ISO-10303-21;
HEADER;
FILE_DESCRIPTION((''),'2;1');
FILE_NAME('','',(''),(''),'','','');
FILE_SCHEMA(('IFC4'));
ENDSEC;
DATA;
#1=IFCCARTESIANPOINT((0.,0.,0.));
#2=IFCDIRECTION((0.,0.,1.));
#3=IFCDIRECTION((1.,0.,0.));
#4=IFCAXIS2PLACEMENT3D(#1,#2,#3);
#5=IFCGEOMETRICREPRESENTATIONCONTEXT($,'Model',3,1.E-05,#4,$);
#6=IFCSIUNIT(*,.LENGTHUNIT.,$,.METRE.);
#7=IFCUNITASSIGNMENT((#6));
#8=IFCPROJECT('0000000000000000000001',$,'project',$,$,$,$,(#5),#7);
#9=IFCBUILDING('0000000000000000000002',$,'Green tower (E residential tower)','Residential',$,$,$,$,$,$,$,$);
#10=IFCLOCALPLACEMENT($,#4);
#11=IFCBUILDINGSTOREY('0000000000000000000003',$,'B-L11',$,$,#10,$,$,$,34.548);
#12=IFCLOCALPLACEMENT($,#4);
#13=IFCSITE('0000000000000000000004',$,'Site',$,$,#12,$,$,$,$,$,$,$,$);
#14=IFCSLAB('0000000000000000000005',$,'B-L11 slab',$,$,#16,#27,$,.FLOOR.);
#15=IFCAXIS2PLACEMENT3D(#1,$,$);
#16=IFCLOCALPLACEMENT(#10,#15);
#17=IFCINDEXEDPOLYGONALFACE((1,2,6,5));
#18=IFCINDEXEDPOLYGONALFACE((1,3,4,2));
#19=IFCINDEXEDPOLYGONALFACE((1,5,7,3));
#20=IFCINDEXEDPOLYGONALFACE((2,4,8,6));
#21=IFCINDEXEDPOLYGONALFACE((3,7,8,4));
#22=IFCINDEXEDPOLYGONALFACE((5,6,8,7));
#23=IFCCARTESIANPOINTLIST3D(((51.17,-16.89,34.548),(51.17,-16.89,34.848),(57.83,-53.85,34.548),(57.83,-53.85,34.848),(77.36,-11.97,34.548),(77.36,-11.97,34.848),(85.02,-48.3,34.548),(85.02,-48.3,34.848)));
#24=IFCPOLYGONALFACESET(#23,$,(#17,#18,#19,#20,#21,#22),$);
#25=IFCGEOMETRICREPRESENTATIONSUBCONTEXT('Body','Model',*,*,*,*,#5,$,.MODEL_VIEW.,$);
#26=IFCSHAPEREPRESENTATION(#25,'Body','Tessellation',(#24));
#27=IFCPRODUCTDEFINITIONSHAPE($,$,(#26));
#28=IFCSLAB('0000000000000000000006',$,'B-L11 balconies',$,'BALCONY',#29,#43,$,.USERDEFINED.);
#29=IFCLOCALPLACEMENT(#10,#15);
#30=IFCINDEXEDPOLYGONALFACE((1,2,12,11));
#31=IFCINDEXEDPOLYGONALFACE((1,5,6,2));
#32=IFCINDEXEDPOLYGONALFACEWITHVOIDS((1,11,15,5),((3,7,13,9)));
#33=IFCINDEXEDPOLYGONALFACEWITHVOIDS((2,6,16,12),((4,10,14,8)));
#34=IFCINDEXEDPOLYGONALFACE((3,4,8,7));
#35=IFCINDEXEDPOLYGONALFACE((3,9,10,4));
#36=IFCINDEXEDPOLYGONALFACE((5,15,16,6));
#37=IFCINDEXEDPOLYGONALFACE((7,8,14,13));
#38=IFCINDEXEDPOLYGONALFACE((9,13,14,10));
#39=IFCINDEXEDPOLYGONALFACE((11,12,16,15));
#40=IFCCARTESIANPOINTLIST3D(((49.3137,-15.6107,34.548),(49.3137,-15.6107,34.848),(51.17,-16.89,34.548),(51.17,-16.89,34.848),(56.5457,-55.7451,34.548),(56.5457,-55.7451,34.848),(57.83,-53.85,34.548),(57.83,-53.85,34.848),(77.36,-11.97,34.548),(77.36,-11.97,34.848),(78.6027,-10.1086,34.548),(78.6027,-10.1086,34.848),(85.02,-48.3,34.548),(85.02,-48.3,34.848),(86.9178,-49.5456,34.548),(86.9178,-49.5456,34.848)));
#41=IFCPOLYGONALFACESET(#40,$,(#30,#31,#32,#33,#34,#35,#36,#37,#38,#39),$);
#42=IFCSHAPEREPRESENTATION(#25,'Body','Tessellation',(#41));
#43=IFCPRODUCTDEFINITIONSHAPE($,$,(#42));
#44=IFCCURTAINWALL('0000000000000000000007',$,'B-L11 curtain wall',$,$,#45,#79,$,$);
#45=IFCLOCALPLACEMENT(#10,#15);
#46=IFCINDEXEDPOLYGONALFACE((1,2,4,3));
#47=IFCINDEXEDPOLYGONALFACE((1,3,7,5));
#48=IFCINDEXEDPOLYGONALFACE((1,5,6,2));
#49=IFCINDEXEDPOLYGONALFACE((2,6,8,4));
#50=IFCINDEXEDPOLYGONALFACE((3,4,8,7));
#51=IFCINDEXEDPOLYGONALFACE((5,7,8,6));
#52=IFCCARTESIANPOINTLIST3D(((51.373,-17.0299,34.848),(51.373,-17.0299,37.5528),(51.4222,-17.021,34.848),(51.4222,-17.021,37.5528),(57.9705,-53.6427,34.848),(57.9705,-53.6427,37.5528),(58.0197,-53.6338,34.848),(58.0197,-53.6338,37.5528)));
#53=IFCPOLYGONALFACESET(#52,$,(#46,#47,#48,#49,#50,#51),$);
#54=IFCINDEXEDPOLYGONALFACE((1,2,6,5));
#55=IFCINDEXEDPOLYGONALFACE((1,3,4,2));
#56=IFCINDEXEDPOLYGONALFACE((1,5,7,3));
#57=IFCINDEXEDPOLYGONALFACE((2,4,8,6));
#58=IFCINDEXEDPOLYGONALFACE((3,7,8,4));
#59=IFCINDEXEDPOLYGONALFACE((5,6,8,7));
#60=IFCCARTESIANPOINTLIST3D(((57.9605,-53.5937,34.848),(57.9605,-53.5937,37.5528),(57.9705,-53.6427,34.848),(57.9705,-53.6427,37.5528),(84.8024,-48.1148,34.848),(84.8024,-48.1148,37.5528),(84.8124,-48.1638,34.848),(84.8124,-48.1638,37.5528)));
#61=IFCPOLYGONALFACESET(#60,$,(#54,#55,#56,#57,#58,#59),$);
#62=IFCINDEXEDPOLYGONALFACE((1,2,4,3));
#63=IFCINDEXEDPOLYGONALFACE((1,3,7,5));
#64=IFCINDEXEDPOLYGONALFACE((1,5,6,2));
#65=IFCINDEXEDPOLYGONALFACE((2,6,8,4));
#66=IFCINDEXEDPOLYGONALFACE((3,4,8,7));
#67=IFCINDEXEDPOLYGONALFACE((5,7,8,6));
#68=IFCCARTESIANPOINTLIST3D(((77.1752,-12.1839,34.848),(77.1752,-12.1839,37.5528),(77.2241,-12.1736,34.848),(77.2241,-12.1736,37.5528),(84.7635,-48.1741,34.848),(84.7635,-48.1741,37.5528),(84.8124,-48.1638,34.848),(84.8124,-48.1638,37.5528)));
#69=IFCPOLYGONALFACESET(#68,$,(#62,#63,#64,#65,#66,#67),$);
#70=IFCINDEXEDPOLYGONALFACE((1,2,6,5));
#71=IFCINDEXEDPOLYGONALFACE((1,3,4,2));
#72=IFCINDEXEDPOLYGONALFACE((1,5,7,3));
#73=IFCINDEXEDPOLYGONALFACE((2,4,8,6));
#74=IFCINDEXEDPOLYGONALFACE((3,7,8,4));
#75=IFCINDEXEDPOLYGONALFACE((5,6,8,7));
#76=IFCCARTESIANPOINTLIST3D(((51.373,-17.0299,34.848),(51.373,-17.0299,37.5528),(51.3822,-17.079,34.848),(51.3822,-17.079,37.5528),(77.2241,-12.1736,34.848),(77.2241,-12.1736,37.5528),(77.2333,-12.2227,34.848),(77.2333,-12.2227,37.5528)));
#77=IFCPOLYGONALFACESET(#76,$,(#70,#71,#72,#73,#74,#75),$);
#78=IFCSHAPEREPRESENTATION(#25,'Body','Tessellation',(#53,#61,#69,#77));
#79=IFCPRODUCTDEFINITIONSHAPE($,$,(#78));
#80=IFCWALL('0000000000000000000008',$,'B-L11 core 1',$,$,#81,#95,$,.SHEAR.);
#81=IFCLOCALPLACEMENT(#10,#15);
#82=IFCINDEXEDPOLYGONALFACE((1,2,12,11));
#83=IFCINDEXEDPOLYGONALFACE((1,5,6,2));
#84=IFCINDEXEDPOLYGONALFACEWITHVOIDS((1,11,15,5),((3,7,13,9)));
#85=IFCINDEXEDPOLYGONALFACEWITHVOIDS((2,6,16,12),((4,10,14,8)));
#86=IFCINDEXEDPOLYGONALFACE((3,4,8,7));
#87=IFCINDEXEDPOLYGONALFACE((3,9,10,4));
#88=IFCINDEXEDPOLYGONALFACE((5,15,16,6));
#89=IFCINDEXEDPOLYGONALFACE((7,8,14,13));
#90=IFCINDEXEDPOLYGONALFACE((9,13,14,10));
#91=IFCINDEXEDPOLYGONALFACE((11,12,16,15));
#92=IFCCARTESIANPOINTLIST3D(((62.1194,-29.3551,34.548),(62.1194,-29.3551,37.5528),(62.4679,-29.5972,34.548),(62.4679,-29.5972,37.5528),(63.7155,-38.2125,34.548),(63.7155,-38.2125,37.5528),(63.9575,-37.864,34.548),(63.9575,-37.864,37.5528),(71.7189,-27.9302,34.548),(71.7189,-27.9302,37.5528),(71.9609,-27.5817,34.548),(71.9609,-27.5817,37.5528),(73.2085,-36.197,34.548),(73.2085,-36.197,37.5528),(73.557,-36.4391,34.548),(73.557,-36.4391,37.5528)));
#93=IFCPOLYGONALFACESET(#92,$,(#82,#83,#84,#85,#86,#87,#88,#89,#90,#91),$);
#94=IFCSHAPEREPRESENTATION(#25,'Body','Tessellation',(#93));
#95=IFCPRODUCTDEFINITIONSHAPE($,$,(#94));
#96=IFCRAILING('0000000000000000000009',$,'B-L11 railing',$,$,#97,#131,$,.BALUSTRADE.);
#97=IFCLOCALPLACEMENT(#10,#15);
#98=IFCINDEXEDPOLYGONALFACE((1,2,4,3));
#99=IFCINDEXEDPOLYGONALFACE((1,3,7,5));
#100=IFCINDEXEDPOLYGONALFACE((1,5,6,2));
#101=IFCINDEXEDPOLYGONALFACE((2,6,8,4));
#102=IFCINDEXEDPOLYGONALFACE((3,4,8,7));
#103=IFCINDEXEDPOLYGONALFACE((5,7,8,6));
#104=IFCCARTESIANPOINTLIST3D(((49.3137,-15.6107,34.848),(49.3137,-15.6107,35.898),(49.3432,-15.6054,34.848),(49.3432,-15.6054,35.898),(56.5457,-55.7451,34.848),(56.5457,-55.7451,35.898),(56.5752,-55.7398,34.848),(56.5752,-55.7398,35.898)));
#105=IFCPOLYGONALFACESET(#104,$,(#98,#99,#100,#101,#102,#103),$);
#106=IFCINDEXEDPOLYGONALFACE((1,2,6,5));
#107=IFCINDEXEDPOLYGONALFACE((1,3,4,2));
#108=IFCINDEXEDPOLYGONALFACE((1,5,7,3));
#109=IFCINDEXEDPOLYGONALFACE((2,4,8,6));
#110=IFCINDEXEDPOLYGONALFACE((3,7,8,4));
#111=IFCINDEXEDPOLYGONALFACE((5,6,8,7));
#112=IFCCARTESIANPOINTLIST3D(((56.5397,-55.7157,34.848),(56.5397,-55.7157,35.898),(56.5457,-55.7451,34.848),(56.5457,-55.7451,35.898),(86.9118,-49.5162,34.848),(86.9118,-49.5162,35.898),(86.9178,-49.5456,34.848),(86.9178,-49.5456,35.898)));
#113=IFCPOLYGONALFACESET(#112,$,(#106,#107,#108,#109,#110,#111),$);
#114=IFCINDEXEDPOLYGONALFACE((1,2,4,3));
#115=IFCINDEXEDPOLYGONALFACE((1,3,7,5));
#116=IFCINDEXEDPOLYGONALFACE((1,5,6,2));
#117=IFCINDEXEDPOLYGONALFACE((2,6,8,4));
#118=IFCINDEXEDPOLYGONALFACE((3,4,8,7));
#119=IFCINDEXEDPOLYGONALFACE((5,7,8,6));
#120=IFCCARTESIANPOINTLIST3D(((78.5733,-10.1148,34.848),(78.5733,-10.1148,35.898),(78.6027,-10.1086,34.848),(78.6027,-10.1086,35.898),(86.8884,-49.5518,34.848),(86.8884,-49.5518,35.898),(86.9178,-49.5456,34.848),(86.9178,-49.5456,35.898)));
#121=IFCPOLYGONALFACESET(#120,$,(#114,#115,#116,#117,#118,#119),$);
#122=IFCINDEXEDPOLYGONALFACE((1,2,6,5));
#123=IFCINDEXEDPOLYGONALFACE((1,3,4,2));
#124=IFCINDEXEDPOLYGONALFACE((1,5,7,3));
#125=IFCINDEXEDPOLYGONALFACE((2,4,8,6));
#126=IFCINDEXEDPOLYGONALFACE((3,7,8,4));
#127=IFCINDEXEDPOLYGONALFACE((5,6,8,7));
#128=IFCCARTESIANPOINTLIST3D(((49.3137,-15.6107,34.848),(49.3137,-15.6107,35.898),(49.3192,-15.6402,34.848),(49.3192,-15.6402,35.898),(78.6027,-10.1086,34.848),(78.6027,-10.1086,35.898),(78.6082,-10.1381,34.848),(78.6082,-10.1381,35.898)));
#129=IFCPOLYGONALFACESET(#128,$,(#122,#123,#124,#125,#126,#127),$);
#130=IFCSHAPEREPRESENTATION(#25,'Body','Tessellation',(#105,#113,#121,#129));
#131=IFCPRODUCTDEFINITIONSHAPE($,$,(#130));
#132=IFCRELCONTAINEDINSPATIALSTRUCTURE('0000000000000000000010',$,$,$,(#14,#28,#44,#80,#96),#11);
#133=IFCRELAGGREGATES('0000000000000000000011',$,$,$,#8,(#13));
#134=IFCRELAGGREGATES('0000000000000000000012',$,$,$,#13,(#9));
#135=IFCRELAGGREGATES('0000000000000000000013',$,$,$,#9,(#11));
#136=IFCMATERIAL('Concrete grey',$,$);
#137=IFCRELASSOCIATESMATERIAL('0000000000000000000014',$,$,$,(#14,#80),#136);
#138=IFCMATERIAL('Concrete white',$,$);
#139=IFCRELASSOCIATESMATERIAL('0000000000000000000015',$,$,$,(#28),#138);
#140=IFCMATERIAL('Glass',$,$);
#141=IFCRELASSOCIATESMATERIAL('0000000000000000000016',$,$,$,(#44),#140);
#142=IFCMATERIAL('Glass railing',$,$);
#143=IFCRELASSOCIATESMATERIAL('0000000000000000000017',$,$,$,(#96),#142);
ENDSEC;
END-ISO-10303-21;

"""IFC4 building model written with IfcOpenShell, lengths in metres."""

from ifc_helpers import new_model, si_unit, frame, origin_with_axes, place, context, subcontext, project, spatial, polyline, outline, extrude, material, element, save


model = new_model("IFC4")

# Units and contexts
model_context = context("Model", 3, precision=1e-05, world=origin_with_axes())
body_context = subcontext(model_context, "Body", "Model", "MODEL_VIEW")
ifc_project = project(units=[si_unit("LENGTHUNIT", "METRE")], contexts=[model_context])

# Site, building, storey
site_placement = place(None, origin_with_axes())
site = spatial("IfcSite", under=ifc_project, at=site_placement, Name="Site")
building = spatial("IfcBuilding", under=site, Name="Green tower (E residential tower)", Description="Residential")
storey_placement = place(None, origin_with_axes())
storey = spatial("IfcBuildingStorey", under=building, at=storey_placement, Name="B-L11", Elevation=34.548)

# Slabs
ifc_material_1 = material(Name="Concrete grey")
slab_1_placement = place(storey_placement, origin_with_axes())
element("IfcSlab", 1, at=slab_1_placement, inside=storey, material=ifc_material_1, Name="B-L11 slab", PredefinedType="FLOOR", context=body_context, shape_type="SweptSolid", body=[
    extrude(outline(polyline([(51.17, -16.89), (57.83, -53.85), (85.02, -48.3), (77.36, -11.97), (51.17, -16.89)])), frame((0.0, 0.0, 34.548), z_axis=(0.0, 0.0, 1.0), x_axis=(1.0, 0.0, 0.0)), (0.0, 0.0, 1.0), 0.3),
])
ifc_material_2 = material(Name="Concrete white")
slab_2_placement = place(storey_placement, origin_with_axes())
element("IfcSlab", 2, at=slab_2_placement, inside=storey, material=ifc_material_2, Name="B-L11 balconies", ObjectType="BALCONY", PredefinedType="USERDEFINED", context=body_context, shape_type="SweptSolid", body=[
    extrude(outline(polyline([(49.3137, -15.6107), (56.5457, -55.7451), (86.9178, -49.5456), (78.6027, -10.1086), (49.3137, -15.6107)]), holes=[polyline([(51.17, -16.89), (57.83, -53.85), (85.02, -48.3), (77.36, -11.97), (51.17, -16.89)])]), frame((0.0, 0.0, 34.548), z_axis=(0.0, 0.0, 1.0), x_axis=(1.0, 0.0, 0.0)), (0.0, 0.0, 1.0), 0.3),
])

# Curtain wall
ifc_material_3 = material(Name="Glass")
curtain_wall_placement = place(storey_placement, origin_with_axes())
element("IfcCurtainWall", 3, at=curtain_wall_placement, inside=storey, material=ifc_material_3, Name="B-L11 curtain wall", context=body_context, shape_type="SweptSolid", body=[
    extrude(outline(polyline([(51.373, -17.0299), (57.9705, -53.6427), (58.0197, -53.6338), (51.4222, -17.021), (51.373, -17.0299)])), frame((0.0, 0.0, 34.848), z_axis=(0.0, 0.0, 1.0), x_axis=(1.0, 0.0, 0.0)), (0.0, 0.0, 1.0), 2.7048),
    extrude(outline(polyline([(57.9705, -53.6427), (84.8124, -48.1638), (84.8024, -48.1148), (57.9605, -53.5937), (57.9705, -53.6427)])), frame((0.0, 0.0, 34.848), z_axis=(0.0, 0.0, 1.0), x_axis=(1.0, 0.0, 0.0)), (0.0, 0.0, 1.0), 2.7048),
    extrude(outline(polyline([(84.8124, -48.1638), (77.2241, -12.1736), (77.1752, -12.1839), (84.7635, -48.1741), (84.8124, -48.1638)])), frame((0.0, 0.0, 34.848), z_axis=(0.0, 0.0, 1.0), x_axis=(1.0, 0.0, 0.0)), (0.0, 0.0, 1.0), 2.7048),
    extrude(outline(polyline([(77.2241, -12.1736), (51.373, -17.0299), (51.3822, -17.079), (77.2333, -12.2227), (77.2241, -12.1736)])), frame((0.0, 0.0, 34.848), z_axis=(0.0, 0.0, 1.0), x_axis=(1.0, 0.0, 0.0)), (0.0, 0.0, 1.0), 2.7048),
])

# Wall
wall_placement = place(storey_placement, origin_with_axes())
element("IfcWall", 4, at=wall_placement, inside=storey, material=ifc_material_1, Name="B-L11 core 1", PredefinedType="SHEAR", context=body_context, shape_type="SweptSolid", body=[
    extrude(outline(polyline([(62.1194, -29.3551), (63.7155, -38.2125), (73.557, -36.4391), (71.9609, -27.5817), (62.1194, -29.3551)]), holes=[polyline([(62.4679, -29.5972), (63.9575, -37.864), (73.2085, -36.197), (71.7189, -27.9302), (62.4679, -29.5972)])]), frame((0.0, 0.0, 34.548), z_axis=(0.0, 0.0, 1.0), x_axis=(1.0, 0.0, 0.0)), (0.0, 0.0, 1.0), 3.0048),
])

# Railing
ifc_material_4 = material(Name="Glass railing")
railing_placement = place(storey_placement, origin_with_axes())
element("IfcRailing", 5, at=railing_placement, inside=storey, material=ifc_material_4, Name="B-L11 railing", PredefinedType="BALUSTRADE", context=body_context, shape_type="SweptSolid", body=[
    extrude(outline(polyline([(49.3137, -15.6107), (56.5457, -55.7451), (56.5752, -55.7398), (49.3432, -15.6054), (49.3137, -15.6107)])), frame((0.0, 0.0, 34.848), z_axis=(0.0, 0.0, 1.0), x_axis=(1.0, 0.0, 0.0)), (0.0, 0.0, 1.0), 1.05),
    extrude(outline(polyline([(56.5457, -55.7451), (86.9178, -49.5456), (86.9118, -49.5162), (56.5397, -55.7157), (56.5457, -55.7451)])), frame((0.0, 0.0, 34.848), z_axis=(0.0, 0.0, 1.0), x_axis=(1.0, 0.0, 0.0)), (0.0, 0.0, 1.0), 1.05),
    extrude(outline(polyline([(86.9178, -49.5456), (78.6027, -10.1086), (78.5733, -10.1148), (86.8884, -49.5518), (86.9178, -49.5456)])), frame((0.0, 0.0, 34.848), z_axis=(0.0, 0.0, 1.0), x_axis=(1.0, 0.0, 0.0)), (0.0, 0.0, 1.0), 1.05),
    extrude(outline(polyline([(78.6027, -10.1086), (49.3137, -15.6107), (49.3192, -15.6402), (78.6082, -10.1381), (78.6027, -10.1086)])), frame((0.0, 0.0, 34.848), z_axis=(0.0, 0.0, 1.0), x_axis=(1.0, 0.0, 0.0)), (0.0, 0.0, 1.0), 1.05),
])

save(model, "model.ifc")
